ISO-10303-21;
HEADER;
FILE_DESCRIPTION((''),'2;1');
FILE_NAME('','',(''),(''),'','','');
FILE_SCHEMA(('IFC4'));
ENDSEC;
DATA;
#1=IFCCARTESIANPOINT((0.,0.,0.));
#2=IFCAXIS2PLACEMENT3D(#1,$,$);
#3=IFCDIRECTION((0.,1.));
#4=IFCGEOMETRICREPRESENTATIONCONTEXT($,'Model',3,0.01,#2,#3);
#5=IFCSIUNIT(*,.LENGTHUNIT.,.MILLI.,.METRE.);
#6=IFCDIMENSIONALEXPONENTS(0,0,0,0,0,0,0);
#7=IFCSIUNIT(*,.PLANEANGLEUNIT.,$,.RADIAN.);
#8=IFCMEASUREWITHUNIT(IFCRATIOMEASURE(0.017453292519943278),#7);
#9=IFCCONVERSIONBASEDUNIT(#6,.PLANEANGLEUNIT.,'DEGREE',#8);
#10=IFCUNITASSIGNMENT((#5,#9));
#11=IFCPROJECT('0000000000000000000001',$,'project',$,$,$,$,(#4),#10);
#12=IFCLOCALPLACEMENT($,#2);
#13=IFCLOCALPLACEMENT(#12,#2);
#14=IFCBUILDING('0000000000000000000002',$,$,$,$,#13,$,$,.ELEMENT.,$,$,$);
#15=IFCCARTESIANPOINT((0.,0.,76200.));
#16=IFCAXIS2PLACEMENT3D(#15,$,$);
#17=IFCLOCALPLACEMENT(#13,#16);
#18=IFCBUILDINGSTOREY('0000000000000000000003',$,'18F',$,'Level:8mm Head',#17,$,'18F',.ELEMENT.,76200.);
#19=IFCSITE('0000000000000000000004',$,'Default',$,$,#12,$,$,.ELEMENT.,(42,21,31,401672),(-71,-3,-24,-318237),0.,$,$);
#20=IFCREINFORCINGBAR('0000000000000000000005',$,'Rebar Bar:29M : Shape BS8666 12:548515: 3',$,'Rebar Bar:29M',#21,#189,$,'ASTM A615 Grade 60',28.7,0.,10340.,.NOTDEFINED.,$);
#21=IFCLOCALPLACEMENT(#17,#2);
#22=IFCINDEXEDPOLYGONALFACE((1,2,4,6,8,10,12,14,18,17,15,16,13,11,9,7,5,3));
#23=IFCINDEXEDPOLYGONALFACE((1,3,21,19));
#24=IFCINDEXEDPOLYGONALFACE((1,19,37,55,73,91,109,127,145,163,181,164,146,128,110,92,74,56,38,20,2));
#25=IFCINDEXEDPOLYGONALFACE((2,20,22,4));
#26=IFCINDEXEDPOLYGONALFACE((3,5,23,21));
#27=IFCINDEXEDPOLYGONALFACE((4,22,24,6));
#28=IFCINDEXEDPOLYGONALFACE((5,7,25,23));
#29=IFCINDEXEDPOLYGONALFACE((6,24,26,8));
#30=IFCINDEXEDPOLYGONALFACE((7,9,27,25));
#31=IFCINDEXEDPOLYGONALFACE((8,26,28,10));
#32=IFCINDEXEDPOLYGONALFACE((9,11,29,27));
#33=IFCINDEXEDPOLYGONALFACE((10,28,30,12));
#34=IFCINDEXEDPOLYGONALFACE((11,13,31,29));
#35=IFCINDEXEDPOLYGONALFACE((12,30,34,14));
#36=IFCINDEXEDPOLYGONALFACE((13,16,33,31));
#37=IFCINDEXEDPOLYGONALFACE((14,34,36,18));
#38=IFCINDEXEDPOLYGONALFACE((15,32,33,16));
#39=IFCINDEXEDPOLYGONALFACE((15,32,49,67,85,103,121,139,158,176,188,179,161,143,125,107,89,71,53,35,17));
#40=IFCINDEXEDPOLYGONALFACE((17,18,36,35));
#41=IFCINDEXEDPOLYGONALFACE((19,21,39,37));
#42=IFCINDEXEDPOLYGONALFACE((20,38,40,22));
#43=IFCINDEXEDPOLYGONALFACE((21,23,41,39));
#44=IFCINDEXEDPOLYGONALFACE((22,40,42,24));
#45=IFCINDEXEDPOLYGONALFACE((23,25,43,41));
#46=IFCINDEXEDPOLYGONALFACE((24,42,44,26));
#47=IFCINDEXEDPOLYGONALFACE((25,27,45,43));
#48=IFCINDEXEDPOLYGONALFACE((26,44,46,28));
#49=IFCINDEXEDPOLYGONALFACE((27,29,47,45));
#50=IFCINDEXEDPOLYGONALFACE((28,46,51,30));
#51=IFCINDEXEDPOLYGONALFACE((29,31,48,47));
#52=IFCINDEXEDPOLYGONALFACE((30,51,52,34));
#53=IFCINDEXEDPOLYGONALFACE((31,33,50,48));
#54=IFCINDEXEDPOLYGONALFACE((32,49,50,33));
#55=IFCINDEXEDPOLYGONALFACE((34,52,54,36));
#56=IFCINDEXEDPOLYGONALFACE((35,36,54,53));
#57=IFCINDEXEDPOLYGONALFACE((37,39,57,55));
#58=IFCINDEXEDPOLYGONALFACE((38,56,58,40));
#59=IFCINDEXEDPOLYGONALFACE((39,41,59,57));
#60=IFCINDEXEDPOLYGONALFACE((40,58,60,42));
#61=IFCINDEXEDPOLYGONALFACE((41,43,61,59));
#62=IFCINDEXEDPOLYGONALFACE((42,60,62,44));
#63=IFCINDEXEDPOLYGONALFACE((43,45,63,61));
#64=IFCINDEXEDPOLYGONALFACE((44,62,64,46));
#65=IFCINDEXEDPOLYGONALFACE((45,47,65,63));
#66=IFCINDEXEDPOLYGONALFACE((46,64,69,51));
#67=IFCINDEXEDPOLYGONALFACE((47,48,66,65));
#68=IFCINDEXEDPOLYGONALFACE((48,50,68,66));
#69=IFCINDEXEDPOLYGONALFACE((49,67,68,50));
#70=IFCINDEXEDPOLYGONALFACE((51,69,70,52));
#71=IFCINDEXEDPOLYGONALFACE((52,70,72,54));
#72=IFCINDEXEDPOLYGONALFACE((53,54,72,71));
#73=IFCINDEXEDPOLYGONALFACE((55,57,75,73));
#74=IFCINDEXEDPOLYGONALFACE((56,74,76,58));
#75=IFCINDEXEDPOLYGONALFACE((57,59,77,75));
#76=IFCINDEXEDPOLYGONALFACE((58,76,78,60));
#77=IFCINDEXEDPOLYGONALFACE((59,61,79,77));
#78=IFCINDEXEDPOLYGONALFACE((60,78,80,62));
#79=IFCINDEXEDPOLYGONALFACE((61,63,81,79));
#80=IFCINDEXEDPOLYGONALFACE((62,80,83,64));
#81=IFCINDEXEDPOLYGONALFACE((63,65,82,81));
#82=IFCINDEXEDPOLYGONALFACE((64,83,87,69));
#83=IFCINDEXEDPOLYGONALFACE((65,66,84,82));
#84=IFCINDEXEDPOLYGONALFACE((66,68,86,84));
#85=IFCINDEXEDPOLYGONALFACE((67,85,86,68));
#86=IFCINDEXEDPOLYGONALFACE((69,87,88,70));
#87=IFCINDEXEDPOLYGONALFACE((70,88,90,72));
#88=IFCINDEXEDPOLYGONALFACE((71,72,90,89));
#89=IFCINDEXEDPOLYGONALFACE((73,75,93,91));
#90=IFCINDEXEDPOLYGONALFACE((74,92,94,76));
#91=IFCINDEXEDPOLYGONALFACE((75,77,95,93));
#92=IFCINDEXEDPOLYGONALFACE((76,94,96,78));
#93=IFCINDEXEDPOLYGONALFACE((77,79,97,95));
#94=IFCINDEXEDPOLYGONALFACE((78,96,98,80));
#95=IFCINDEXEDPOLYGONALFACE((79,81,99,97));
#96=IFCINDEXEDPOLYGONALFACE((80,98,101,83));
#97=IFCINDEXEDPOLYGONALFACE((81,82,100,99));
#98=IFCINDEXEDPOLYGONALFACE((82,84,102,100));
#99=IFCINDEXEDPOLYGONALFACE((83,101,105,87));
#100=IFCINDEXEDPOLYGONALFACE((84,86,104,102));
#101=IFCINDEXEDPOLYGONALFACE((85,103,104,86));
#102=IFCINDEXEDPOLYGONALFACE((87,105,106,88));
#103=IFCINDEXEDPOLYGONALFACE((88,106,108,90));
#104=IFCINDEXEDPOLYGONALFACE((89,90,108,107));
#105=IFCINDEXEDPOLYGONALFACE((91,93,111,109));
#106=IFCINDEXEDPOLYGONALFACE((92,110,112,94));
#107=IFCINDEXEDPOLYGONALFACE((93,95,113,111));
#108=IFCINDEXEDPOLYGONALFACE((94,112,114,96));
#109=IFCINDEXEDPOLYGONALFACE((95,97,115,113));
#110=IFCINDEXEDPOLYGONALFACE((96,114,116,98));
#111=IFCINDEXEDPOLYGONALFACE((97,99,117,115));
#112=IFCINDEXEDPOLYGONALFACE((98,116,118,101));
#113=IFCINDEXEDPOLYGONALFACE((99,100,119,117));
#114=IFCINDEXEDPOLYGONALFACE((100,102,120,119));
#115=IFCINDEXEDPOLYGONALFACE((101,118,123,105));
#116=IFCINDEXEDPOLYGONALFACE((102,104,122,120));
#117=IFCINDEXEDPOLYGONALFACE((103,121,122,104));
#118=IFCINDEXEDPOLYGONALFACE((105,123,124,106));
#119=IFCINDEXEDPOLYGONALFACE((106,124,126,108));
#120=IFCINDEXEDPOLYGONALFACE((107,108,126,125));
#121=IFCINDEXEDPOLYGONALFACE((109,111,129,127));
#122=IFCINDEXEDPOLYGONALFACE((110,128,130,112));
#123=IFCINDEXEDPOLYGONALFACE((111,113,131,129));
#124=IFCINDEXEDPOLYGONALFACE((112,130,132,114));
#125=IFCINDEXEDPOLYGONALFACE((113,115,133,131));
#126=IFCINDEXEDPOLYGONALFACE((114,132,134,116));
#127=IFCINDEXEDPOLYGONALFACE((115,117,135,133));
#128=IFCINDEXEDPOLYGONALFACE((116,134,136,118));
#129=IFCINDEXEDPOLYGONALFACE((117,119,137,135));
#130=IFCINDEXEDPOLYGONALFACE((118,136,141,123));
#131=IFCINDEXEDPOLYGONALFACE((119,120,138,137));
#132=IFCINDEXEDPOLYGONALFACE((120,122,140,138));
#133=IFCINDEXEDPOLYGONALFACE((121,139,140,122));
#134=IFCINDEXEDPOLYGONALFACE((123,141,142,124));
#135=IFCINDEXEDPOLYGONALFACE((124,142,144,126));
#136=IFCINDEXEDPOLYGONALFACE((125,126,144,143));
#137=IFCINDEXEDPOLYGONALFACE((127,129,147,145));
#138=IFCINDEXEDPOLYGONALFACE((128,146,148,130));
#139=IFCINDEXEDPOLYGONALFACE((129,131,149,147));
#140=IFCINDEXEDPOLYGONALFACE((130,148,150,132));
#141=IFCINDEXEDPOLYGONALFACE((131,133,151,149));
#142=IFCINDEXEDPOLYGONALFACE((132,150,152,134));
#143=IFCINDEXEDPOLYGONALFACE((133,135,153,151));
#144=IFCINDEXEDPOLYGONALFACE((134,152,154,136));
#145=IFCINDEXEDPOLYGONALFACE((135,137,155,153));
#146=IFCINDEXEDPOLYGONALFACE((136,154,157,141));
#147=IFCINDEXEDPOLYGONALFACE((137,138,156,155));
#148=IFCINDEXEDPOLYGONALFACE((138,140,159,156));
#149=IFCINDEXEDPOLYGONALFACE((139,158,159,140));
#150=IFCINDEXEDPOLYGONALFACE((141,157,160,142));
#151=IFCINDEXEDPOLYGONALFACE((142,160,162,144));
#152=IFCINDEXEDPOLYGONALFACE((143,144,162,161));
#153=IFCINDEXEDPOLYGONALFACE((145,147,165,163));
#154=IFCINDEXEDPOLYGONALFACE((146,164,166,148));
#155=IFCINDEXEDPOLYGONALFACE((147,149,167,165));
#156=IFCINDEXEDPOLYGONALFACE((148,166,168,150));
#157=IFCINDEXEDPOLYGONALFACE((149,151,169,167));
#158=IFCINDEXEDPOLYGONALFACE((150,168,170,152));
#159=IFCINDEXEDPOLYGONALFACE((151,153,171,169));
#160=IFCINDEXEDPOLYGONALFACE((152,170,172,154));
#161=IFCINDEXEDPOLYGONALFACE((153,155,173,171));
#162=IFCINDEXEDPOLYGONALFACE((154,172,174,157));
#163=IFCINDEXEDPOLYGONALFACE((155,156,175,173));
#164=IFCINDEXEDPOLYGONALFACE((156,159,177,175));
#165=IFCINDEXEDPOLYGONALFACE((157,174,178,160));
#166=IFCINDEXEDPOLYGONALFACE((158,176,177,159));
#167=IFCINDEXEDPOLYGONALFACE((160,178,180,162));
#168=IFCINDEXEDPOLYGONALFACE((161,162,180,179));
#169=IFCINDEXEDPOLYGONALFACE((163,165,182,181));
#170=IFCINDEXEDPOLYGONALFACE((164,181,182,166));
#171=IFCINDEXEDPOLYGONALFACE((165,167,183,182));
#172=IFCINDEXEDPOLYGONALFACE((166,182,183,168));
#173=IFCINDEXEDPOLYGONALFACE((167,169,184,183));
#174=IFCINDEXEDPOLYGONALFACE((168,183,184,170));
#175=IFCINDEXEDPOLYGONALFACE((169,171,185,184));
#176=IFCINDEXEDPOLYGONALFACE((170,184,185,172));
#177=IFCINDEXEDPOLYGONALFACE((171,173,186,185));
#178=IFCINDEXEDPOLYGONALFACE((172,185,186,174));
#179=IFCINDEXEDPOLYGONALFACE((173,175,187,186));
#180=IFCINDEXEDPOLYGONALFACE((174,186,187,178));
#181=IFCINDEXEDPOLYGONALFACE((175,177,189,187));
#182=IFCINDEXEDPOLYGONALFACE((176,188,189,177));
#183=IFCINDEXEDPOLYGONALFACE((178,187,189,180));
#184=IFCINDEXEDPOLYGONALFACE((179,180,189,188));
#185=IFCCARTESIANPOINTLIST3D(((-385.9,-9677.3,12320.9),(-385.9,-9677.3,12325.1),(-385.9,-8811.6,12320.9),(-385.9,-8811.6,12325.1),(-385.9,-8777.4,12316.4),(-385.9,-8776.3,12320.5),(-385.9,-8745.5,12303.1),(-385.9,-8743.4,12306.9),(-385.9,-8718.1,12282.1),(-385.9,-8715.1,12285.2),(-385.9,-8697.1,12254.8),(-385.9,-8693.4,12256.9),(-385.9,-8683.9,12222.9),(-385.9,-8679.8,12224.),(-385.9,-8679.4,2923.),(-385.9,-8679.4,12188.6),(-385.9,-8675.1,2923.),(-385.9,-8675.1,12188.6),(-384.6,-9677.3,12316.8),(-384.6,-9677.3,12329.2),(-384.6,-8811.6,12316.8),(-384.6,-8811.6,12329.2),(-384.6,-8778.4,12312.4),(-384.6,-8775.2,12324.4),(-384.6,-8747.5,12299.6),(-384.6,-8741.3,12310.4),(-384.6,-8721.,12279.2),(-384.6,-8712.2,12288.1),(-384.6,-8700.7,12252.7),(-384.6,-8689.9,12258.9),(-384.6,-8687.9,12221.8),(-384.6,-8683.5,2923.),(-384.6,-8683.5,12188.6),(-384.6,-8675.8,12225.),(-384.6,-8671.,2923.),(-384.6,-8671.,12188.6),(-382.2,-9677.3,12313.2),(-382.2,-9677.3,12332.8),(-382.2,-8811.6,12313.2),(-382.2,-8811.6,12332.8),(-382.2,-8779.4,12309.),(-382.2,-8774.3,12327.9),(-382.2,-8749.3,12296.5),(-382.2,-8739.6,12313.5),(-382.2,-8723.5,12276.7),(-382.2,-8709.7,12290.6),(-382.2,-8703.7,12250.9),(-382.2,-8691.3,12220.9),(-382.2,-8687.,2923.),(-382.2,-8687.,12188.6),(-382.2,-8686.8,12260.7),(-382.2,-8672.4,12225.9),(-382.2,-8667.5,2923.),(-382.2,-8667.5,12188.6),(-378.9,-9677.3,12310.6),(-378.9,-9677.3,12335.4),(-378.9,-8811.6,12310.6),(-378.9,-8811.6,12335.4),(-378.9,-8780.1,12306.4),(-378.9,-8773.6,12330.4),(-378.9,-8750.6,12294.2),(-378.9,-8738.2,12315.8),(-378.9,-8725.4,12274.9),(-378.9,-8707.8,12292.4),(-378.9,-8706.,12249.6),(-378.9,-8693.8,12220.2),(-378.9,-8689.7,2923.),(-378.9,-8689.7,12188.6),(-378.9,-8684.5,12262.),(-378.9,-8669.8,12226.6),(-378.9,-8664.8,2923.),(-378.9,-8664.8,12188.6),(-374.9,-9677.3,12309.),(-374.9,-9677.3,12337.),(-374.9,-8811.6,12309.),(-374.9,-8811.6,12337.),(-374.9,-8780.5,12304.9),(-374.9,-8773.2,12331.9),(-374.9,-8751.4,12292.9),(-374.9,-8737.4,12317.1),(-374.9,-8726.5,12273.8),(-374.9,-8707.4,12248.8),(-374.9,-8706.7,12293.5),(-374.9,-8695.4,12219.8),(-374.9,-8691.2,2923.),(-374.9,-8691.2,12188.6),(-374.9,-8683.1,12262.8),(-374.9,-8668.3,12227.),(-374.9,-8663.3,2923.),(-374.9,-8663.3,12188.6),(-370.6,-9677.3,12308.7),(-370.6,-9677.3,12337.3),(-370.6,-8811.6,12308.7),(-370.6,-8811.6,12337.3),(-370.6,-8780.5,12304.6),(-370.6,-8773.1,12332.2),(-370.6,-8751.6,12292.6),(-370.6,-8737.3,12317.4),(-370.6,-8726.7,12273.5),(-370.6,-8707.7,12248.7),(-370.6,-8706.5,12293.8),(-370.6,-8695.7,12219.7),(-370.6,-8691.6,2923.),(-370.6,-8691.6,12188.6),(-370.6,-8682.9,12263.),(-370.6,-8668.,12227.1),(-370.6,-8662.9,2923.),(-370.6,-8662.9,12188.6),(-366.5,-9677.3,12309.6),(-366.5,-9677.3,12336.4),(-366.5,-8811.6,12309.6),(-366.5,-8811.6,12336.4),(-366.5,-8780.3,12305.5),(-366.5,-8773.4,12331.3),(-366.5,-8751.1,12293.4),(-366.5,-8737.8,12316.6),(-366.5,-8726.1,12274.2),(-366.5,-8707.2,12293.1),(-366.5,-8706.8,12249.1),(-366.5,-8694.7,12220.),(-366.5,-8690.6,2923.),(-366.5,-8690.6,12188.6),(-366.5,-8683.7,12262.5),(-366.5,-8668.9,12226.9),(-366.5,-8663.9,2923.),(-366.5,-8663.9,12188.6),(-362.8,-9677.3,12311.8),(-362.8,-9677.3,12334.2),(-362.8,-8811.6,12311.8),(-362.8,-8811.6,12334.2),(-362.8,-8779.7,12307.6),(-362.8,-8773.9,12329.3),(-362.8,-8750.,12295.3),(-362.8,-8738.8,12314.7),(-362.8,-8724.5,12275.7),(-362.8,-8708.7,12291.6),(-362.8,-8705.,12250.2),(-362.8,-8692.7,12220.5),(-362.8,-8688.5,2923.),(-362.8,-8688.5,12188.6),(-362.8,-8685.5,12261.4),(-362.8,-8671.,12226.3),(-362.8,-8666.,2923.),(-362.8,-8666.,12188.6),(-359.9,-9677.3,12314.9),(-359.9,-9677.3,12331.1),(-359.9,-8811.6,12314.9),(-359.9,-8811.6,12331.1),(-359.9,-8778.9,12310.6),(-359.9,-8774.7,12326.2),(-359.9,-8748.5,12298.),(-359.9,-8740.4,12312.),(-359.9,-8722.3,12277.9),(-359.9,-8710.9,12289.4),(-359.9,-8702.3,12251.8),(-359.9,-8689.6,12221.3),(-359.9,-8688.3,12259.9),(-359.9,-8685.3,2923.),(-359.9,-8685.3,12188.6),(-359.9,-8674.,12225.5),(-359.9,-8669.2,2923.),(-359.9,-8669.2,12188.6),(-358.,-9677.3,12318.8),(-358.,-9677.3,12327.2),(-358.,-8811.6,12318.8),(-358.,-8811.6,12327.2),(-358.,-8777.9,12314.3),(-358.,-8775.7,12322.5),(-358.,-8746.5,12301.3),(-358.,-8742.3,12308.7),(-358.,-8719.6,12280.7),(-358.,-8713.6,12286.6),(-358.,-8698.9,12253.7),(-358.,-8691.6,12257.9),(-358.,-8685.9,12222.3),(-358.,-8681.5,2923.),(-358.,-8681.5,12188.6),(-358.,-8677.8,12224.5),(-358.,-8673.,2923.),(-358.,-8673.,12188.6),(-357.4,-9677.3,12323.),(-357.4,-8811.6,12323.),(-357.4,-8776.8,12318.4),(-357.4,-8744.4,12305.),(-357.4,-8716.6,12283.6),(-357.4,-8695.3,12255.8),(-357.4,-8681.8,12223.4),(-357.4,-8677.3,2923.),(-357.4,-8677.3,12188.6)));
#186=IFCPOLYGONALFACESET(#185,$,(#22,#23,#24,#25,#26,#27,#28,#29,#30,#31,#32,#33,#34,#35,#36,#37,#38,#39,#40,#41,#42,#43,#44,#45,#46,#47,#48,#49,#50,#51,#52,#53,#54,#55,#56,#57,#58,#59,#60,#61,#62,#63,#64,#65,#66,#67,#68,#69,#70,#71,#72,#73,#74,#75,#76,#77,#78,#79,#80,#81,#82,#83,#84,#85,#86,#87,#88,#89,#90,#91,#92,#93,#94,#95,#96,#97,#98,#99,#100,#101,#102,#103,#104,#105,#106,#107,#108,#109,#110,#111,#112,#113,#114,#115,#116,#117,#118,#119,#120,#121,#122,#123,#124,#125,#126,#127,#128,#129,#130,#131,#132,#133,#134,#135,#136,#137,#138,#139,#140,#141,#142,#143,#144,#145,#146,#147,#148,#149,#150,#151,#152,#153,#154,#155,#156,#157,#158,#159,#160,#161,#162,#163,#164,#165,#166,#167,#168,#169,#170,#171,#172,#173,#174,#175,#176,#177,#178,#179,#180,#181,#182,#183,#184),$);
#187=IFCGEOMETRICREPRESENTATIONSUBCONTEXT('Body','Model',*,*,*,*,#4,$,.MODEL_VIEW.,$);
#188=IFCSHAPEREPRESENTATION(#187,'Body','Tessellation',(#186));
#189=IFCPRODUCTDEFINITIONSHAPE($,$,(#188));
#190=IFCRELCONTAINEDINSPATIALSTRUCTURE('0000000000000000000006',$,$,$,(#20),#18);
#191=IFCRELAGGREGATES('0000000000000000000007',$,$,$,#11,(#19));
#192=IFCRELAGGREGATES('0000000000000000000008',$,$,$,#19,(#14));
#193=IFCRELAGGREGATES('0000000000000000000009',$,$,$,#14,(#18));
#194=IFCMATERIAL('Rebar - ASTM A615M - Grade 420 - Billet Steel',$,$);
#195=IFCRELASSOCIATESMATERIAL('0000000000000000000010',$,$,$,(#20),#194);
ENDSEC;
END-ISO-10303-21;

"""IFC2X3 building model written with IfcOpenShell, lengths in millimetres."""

from ifc_helpers import new_model, entity, si_unit, converted_unit, direction, frame, origin, place, context, subcontext, project, spatial, material, element, save


model = new_model("IFC2X3")

# Units and contexts
model_context = context("Model", 3, precision=0.01, world=origin(), true_north=direction((0.0, 1.0)))
body_context = subcontext(model_context, "Body", "Model", "MODEL_VIEW")
ifc_project = project(units=[si_unit("LENGTHUNIT", "METRE", prefix="MILLI"), converted_unit("PLANEANGLEUNIT", "DEGREE", entity("IfcRatioMeasure", 0.017453292519943278), si_unit("PLANEANGLEUNIT", "RADIAN"), dimensions=[0, 0, 0, 0, 0, 0, 0])], contexts=[model_context])

# Site, building, storey
site_placement = place(None, origin())
site = spatial("IfcSite", under=ifc_project, at=site_placement, Name="Default", CompositionType="ELEMENT", RefLatitude=(42, 21, 31, 401672), RefLongitude=(-71, -3, -24, -318237), RefElevation=0.0)
building_placement = place(site_placement, origin())
building = spatial("IfcBuilding", under=site, at=building_placement, CompositionType="ELEMENT")
storey_placement = place(building_placement, frame((0.0, 0.0, 76200.0)))
storey = spatial("IfcBuildingStorey", under=building, at=storey_placement, Name="18F", ObjectType="Level:8mm Head", LongName="18F", CompositionType="ELEMENT", Elevation=76200.0)

# Reinforcing bar
ifc_material_1 = material(Name="Rebar - ASTM A615M - Grade 420 - Billet Steel")
reinforcing_bar_1_placement = place(storey_placement, origin())
element("IfcReinforcingBar", 1, at=reinforcing_bar_1_placement, inside=storey, material=ifc_material_1, Name="Rebar Bar:29M : Shape BS8666 12:548515: 3", SteelGrade="ASTM A615 Grade 60", ObjectType="Rebar Bar:29M", BarLength=10340.0, BarRole="NOTDEFINED", CrossSectionArea=0.0, NominalDiameter=28.7, context=body_context, shape_type="AdvancedSweptSolid", body=[
    entity("IfcSweptDiskSolid", entity("IfcCompositeCurve", [entity("IfcCompositeCurveSegment", "CONTINUOUS", True, entity("IfcPolyline", [entity("IfcCartesianPoint", [-371.7, -8677.3, 2923.0]), entity("IfcCartesianPoint", [-371.7, -8677.3, 12188.6])])), entity("IfcCompositeCurveSegment", "CONTINUOUS", True, entity("IfcTrimmedCurve", entity("IfcCircle", entity("IfcAxis2Placement3D", entity("IfcCartesianPoint", [-371.7, -8811.6, 12188.6]), entity("IfcDirection", [1.0, 0.0, 0.0]), entity("IfcDirection", [0.0, 0.0, 1.0])), 134.3), [entity("IfcParameterValue", 270.0)], [entity("IfcParameterValue", 360.0)], True, "PARAMETER")), entity("IfcCompositeCurveSegment", "CONTINUOUS", True, entity("IfcPolyline", [entity("IfcCartesianPoint", [-371.7, -8811.6, 12323.0]), entity("IfcCartesianPoint", [-371.7, -9677.3, 12323.0])]))], False), 14.3, None, 0.0, 92.0),
])

save(model, "model.ifc")
